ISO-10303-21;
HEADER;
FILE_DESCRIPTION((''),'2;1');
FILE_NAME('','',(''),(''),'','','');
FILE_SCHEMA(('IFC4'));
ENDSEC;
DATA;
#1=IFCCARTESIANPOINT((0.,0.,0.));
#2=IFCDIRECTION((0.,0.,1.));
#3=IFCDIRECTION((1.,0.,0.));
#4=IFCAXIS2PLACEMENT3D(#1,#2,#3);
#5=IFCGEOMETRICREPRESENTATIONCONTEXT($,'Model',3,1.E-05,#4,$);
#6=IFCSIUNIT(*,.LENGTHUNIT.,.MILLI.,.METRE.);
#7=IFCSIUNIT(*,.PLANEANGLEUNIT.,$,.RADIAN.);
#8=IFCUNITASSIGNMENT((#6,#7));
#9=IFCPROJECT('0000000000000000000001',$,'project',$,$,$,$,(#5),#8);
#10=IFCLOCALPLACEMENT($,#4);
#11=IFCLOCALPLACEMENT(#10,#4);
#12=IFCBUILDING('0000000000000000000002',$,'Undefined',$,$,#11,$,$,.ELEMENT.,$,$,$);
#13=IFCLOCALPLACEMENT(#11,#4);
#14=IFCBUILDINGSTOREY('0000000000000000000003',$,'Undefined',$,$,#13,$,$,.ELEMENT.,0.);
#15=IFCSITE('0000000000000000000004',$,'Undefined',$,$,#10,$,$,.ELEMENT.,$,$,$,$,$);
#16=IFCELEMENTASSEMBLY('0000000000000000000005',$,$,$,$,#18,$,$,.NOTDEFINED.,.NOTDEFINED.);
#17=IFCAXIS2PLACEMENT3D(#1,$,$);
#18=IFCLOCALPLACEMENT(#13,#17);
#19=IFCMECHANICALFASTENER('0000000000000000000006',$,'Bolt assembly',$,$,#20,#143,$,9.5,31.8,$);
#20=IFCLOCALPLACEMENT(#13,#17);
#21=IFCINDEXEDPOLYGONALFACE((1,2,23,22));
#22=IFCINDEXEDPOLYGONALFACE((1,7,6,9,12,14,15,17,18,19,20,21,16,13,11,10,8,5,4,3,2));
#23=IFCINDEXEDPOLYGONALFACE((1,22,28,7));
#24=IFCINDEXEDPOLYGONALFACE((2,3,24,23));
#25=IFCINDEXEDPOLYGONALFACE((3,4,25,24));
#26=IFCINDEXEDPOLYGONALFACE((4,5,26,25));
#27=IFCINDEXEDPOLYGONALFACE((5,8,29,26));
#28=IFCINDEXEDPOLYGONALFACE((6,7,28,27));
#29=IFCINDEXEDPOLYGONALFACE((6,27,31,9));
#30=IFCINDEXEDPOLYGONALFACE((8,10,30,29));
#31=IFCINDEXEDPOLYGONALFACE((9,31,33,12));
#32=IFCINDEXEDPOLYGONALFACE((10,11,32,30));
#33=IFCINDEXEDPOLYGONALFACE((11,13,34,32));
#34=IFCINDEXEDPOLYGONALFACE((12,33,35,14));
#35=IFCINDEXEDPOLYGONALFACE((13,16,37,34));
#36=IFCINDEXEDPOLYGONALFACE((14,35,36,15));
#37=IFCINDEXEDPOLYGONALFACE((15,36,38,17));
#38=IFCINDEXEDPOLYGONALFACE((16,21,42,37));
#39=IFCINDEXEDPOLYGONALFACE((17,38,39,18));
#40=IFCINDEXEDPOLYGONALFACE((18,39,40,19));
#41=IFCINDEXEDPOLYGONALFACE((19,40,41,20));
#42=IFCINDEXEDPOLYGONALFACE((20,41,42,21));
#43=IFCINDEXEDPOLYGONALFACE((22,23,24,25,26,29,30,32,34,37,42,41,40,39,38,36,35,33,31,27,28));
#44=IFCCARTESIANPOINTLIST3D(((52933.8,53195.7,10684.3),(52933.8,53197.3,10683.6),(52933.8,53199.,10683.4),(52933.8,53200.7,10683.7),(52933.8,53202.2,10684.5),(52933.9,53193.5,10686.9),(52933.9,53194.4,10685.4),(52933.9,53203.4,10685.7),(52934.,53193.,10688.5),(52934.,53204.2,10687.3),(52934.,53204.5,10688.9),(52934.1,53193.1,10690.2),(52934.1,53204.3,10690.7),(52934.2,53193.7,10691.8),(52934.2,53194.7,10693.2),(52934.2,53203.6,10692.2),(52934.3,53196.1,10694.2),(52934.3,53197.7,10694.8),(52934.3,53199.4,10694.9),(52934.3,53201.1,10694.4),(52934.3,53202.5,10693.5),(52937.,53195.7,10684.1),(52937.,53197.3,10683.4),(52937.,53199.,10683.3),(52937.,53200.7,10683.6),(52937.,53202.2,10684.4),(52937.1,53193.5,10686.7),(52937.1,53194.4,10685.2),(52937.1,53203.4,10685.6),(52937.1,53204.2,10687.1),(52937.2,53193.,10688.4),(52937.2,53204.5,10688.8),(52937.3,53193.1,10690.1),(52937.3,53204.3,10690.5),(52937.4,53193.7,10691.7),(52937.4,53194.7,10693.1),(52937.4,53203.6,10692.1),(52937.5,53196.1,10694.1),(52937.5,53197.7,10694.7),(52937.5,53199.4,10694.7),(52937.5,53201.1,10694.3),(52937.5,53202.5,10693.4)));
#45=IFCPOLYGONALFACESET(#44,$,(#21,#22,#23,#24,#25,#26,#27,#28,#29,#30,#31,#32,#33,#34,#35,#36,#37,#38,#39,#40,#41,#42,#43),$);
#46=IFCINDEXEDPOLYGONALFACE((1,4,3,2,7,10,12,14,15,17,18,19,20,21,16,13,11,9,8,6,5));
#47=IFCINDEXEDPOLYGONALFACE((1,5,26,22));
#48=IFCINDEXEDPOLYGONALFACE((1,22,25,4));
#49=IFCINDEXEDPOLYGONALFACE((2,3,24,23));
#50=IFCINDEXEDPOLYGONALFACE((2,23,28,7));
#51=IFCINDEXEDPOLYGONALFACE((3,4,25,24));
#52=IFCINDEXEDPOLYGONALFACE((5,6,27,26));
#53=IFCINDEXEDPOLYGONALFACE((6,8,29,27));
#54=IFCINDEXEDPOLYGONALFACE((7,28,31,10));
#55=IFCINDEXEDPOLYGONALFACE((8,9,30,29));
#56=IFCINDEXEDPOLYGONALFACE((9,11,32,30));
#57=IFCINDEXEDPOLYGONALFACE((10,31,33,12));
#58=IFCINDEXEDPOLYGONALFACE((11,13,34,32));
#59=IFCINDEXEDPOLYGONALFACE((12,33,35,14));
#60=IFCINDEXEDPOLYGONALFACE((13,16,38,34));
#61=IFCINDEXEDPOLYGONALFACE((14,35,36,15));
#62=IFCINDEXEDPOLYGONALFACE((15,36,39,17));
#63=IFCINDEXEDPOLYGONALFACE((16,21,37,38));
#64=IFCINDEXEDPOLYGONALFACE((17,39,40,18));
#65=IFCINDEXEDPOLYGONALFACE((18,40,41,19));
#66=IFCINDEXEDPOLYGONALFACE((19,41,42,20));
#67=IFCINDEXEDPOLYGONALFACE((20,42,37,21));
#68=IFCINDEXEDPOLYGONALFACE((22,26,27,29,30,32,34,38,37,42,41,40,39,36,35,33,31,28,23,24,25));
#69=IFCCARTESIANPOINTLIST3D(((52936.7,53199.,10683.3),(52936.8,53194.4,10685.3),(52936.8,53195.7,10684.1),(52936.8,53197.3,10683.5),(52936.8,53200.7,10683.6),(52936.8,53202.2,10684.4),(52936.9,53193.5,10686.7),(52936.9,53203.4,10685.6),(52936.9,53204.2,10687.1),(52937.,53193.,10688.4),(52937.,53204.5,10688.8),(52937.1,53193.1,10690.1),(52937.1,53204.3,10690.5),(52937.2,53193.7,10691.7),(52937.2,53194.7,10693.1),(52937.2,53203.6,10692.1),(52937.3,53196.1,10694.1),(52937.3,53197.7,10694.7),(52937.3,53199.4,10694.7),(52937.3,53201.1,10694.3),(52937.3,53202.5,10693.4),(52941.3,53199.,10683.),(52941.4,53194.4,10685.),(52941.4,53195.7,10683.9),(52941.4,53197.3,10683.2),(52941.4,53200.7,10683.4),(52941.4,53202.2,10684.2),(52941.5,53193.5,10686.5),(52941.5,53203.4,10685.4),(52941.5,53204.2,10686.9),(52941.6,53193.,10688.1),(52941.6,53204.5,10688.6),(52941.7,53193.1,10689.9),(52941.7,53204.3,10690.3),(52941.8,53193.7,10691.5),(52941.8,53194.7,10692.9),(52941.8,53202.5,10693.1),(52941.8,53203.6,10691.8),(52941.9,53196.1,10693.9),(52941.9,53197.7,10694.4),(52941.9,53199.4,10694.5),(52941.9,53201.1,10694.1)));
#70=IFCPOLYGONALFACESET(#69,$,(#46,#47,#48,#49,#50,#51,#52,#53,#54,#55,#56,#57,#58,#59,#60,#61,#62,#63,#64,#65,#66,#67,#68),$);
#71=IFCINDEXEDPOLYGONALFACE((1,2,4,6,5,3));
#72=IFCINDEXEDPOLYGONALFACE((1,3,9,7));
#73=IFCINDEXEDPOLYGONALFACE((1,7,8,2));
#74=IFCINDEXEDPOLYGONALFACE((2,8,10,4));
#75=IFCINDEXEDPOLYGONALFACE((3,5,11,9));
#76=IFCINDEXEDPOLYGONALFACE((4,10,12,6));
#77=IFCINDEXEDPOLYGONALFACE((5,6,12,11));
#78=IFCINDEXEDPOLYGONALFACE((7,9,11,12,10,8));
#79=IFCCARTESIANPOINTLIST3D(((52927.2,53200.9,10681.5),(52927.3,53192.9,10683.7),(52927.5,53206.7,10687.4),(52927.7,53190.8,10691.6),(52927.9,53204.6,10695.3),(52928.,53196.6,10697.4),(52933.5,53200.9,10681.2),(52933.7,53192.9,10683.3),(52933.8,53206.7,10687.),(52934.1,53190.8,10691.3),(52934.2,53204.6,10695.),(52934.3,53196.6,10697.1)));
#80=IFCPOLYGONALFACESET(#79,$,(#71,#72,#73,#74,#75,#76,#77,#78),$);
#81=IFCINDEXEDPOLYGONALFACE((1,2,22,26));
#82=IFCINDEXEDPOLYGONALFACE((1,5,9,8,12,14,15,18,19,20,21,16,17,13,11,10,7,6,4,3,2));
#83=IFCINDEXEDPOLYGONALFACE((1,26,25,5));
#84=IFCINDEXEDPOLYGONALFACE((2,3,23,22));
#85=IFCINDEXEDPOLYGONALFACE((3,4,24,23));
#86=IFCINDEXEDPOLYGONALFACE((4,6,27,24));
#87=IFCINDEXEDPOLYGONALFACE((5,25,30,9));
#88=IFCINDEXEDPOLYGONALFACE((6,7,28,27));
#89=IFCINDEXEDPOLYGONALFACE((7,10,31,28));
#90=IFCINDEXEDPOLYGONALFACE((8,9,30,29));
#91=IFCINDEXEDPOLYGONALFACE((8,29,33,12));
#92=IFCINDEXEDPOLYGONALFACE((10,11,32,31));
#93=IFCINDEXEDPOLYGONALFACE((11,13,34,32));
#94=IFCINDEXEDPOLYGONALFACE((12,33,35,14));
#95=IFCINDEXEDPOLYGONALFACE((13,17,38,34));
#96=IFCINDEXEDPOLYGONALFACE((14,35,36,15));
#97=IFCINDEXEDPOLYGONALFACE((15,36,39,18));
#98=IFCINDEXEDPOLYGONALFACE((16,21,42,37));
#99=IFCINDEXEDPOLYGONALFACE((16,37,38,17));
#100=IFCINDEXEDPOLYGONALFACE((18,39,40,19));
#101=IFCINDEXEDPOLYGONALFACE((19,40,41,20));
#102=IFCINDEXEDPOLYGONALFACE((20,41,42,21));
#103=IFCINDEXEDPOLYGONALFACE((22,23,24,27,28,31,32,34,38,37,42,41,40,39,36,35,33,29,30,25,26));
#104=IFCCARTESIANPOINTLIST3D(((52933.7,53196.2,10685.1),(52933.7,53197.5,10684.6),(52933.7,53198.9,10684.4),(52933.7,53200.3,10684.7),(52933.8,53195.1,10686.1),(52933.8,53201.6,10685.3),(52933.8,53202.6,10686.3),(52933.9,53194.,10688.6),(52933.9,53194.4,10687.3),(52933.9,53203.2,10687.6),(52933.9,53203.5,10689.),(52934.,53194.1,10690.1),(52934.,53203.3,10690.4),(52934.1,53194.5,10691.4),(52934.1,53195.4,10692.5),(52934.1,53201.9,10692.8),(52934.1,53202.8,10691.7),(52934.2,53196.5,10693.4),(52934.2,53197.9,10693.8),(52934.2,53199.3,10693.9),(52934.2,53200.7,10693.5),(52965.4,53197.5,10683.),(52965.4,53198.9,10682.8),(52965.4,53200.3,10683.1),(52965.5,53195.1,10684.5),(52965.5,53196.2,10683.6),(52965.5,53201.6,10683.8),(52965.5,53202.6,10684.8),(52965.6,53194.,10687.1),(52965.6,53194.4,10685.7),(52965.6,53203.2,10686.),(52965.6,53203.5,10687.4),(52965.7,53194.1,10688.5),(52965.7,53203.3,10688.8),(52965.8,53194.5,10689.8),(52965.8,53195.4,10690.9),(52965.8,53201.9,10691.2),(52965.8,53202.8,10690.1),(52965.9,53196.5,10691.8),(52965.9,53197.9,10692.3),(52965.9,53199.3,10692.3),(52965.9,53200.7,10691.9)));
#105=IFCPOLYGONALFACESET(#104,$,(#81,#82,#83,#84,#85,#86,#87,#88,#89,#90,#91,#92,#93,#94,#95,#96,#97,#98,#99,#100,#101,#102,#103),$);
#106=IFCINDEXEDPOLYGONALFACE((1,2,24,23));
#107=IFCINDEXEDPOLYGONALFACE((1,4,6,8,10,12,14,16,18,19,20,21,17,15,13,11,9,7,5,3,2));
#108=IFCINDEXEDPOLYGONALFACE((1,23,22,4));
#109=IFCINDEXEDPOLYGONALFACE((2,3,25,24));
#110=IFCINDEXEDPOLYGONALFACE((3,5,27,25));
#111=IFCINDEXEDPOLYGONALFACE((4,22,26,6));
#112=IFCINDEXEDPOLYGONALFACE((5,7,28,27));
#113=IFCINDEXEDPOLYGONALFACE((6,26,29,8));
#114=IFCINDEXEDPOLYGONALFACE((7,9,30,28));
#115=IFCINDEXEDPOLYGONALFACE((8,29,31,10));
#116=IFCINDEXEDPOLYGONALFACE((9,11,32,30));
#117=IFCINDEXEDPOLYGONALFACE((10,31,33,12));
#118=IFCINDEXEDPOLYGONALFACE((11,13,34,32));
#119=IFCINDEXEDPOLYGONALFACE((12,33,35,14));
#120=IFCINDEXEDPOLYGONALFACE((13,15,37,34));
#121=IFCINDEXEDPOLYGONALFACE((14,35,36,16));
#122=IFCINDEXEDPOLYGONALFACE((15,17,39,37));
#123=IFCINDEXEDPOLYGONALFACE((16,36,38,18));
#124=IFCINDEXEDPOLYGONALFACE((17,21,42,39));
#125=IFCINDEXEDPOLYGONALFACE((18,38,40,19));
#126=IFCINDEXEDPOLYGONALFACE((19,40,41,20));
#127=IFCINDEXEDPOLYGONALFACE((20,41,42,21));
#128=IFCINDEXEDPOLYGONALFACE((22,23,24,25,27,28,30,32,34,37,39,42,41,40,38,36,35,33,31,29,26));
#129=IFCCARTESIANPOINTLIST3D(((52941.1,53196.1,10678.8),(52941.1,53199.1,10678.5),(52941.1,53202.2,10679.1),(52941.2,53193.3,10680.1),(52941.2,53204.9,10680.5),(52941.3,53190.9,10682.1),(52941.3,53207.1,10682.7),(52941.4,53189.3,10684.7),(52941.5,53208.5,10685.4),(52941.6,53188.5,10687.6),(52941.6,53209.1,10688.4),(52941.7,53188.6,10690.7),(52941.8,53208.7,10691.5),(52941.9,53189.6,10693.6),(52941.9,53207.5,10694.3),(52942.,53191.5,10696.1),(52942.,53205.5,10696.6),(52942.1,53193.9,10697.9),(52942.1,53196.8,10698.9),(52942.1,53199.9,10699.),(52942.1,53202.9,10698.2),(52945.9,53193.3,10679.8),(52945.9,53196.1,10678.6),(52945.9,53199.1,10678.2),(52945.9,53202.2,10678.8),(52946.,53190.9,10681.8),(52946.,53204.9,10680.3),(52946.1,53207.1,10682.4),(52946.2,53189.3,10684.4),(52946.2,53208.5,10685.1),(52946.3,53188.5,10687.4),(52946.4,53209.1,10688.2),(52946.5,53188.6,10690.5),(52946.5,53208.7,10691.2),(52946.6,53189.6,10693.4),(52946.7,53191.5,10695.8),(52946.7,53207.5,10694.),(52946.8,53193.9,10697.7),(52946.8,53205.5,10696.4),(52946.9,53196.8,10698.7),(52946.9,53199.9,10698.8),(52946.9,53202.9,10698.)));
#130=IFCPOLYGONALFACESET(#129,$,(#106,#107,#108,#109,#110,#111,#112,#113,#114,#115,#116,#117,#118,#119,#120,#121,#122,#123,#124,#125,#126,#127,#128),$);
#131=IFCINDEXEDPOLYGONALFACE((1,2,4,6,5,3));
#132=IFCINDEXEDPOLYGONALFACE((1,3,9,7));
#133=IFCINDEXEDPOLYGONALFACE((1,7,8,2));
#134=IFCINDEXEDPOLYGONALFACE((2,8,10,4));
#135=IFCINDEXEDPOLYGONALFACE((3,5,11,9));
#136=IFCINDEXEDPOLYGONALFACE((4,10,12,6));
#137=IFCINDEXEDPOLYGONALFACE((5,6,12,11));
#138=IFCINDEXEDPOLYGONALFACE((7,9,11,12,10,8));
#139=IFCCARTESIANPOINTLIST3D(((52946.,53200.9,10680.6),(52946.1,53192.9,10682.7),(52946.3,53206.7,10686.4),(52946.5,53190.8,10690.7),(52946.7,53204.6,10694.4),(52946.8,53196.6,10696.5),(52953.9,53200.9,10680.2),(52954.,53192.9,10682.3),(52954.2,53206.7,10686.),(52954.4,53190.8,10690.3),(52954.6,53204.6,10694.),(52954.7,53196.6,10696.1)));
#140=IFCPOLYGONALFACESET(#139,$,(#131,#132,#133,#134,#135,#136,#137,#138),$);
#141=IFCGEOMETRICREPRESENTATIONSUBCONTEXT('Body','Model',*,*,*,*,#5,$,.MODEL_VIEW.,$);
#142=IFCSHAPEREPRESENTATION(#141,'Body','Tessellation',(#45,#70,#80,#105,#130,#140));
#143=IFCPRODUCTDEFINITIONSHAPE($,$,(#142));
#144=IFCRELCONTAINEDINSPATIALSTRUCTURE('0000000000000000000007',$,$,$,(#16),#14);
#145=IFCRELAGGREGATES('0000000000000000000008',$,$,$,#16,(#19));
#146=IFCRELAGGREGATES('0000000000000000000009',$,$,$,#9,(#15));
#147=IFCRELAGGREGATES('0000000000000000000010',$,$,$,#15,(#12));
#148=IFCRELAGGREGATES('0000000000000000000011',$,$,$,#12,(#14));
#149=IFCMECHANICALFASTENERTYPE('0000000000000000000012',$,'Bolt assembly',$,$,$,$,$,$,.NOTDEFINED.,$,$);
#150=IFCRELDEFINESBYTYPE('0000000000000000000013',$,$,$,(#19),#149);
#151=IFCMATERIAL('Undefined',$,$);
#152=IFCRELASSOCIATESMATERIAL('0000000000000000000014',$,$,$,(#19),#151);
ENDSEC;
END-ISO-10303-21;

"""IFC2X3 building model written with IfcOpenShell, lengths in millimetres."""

from ifc_helpers import new_model, si_unit, frame, origin_with_axes, origin_2d_with_axis, place, context, subcontext, project, spatial, polyline, circle, outline, extrude, source, transform, mapped, material, type_object, element, aggregate, save


model = new_model("IFC2X3")

# Units and contexts
model_context = context("Model", 3, precision=1e-05, world=origin_with_axes())
body_context = subcontext(model_context, "Body", "Model", "MODEL_VIEW")
ifc_project = project(units=[si_unit("LENGTHUNIT", "METRE", prefix="MILLI"), si_unit("PLANEANGLEUNIT", "RADIAN")], contexts=[model_context])

# Site, building, storey
site_placement = place(None, origin_with_axes())
site = spatial("IfcSite", under=ifc_project, at=site_placement, Name="Undefined", CompositionType="ELEMENT")
building_placement = place(site_placement, origin_with_axes())
building = spatial("IfcBuilding", under=site, at=building_placement, Name="Undefined", CompositionType="ELEMENT")
storey_placement = place(building_placement, origin_with_axes())
storey = spatial("IfcBuildingStorey", under=building, at=storey_placement, Name="Undefined", CompositionType="ELEMENT", Elevation=0.0)

# Element assembly
assembly_1_placement = place(storey_placement, origin_with_axes())
assembly_1 = element("IfcElementAssembly", 1, at=assembly_1_placement, inside=storey, AssemblyPlace="NOTDEFINED", PredefinedType="NOTDEFINED")

# Shared definitions
ifc_material_1 = material(Name="Undefined")
mechanical_fastener_type = type_object("IfcMechanicalFastenerType", Name="Bolt assembly")

# Mechanical fastener
shared_shape_1 = source(origin_with_axes(), body_context, "Body", "SweptSolid", [
    extrude(circle(Radius=5.8, at=origin_2d_with_axis()), frame((0.0, -7.6, 0.0), z_axis=(0.0, 1.0, 0.0), x_axis=(1.0, 0.0, 0.0)), (0.0, 0.0, 1.0), 3.2),
    extrude(circle(Radius=5.8, at=origin_2d_with_axis()), frame((0.0, -4.6, 0.0), z_axis=(0.0, 1.0, 0.0), x_axis=(1.0, 0.0, 0.0)), (0.0, 0.0, 1.0), 4.6),
    extrude(outline(polyline([(7.1, -4.1), (7.1, 4.1), (0.0, 8.2), (-7.1, 4.1), (-7.1, -4.1), (0.0, -8.2), (7.1, -4.1)])), frame((0.0, -14.0, 0.0), z_axis=(0.0, 1.0, 0.0), x_axis=(1.0, 0.0, 0.0)), (0.0, 0.0, 1.0), 6.3),
    extrude(circle(Radius=4.8, at=origin_2d_with_axis()), frame((0.0, -7.7, 0.0), z_axis=(0.0, 1.0, 0.0), x_axis=(1.0, 0.0, 0.0)), (0.0, 0.0, 1.0), 31.8),
    extrude(circle(Radius=10.3, at=origin_2d_with_axis()), frame((0.0, 0.0, 0.0), z_axis=(0.0, 1.0, 0.0), x_axis=(1.0, 0.0, 0.0)), (0.0, 0.0, 1.0), 4.8),
    extrude(outline(polyline([(7.1, -4.1), (7.1, 4.1), (0.0, 8.2), (-7.1, 4.1), (-7.1, -4.1), (0.0, -8.2), (7.1, -4.1)])), frame((0.0, 4.8, 0.0), z_axis=(0.0, 1.0, 0.0), x_axis=(1.0, 0.0, 0.0)), (0.0, 0.0, 1.0), 7.9),
])
mechanical_fastener_1_placement = place(assembly_1_placement, frame((52941.6, 53198.8, 10688.8), z_axis=(0.035281, 0.707107, 0.706226), x_axis=(0.035282, -0.707107, 0.706226)))
mechanical_fastener_1 = element("IfcMechanicalFastener", 2, at=mechanical_fastener_1_placement, type_object=mechanical_fastener_type, material=ifc_material_1, Name="Bolt assembly", NominalDiameter=9.5, NominalLength=31.8, context=body_context, shape_type="MappedRepresentation", body=[
    mapped(shared_shape_1, transform((0.0, 0.0, 0.0))),
])
aggregate(assembly_1, [mechanical_fastener_1])

save(model, "model.ifc")
